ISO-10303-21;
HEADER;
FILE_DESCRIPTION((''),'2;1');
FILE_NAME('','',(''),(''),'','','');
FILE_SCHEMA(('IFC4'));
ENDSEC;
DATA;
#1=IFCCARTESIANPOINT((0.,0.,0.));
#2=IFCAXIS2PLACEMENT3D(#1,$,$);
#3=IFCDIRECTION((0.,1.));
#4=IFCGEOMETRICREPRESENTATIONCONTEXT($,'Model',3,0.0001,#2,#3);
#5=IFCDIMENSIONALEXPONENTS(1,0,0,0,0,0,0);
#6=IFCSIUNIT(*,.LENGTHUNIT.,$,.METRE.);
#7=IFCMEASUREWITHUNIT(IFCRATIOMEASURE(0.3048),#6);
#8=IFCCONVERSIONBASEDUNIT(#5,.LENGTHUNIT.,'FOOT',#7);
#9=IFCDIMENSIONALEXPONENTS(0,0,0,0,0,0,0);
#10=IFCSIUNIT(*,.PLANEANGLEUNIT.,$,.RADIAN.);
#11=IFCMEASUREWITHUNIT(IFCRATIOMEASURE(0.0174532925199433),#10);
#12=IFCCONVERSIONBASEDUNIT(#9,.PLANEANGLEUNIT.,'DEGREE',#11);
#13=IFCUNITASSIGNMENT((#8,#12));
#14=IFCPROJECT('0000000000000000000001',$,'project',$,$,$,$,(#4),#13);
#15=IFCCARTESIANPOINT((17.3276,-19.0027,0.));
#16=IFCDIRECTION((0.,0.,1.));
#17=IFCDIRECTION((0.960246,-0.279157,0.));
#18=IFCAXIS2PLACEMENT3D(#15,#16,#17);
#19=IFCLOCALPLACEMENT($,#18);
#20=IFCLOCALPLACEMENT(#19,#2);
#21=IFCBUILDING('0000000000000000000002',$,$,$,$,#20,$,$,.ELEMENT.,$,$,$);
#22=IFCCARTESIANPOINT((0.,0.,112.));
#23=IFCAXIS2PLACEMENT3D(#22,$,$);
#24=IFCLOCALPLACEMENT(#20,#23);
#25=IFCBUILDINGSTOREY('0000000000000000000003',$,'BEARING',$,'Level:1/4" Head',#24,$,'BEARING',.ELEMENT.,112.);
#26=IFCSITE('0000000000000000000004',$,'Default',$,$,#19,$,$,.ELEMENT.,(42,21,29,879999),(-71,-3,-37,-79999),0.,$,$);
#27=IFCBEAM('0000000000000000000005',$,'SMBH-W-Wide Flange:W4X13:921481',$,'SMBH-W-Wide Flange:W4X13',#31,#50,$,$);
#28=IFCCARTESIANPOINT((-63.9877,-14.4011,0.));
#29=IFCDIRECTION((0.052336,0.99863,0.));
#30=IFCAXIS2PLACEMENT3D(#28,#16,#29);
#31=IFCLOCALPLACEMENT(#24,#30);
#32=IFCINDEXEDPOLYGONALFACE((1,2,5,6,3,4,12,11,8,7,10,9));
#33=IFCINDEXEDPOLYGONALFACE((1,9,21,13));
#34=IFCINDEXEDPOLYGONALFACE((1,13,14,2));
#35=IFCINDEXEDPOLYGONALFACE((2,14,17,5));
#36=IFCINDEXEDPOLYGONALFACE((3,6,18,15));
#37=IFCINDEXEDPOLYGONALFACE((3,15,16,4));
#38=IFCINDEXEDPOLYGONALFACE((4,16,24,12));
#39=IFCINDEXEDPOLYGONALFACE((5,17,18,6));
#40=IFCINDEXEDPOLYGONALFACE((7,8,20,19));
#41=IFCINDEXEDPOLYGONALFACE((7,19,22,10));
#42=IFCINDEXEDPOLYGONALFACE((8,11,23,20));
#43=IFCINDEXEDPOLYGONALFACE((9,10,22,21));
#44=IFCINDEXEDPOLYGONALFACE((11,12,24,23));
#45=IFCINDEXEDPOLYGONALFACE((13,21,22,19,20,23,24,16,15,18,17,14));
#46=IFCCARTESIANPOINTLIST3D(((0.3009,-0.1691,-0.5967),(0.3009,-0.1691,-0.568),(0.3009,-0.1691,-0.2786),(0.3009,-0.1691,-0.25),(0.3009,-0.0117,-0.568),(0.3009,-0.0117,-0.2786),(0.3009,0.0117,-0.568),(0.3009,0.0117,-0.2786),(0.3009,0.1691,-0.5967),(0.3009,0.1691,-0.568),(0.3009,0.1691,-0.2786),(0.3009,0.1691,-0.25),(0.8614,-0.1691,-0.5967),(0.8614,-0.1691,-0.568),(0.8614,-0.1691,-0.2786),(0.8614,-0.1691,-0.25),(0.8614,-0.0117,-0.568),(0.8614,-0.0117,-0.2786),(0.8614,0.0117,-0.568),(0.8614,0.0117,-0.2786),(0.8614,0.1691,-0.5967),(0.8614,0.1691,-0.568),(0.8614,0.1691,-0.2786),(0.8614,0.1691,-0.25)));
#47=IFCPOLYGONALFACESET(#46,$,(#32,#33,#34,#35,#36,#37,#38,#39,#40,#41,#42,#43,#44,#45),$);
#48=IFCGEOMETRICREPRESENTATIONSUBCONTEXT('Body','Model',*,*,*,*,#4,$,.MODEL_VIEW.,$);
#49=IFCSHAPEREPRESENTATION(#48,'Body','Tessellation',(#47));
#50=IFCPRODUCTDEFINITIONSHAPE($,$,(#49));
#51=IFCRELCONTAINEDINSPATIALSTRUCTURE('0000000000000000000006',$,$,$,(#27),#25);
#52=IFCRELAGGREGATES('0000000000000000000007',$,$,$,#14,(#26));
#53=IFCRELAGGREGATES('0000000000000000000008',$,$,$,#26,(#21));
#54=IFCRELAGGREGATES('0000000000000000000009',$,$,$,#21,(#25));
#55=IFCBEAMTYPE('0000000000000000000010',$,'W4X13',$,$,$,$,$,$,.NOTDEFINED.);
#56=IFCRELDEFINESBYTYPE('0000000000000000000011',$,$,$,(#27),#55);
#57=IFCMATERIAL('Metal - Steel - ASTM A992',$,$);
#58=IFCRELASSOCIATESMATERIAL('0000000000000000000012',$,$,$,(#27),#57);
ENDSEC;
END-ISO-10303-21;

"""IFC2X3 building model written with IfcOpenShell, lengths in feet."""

from ifc_helpers import new_model, entity, si_unit, converted_unit, direction, frame, frame_2d, origin, place, context, subcontext, project, spatial, i_section, extrude, material, type_object, element, save


model = new_model("IFC2X3")

# Units and contexts
model_context = context("Model", 3, precision=0.0001, world=origin(), true_north=direction((0.0, 1.0)))
body_context = subcontext(model_context, "Body", "Model", "MODEL_VIEW")
ifc_project = project(units=[converted_unit("LENGTHUNIT", "FOOT", entity("IfcRatioMeasure", 0.3048), si_unit("LENGTHUNIT", "METRE"), dimensions=[1, 0, 0, 0, 0, 0, 0]), converted_unit("PLANEANGLEUNIT", "DEGREE", entity("IfcRatioMeasure", 0.0174532925199433), si_unit("PLANEANGLEUNIT", "RADIAN"), dimensions=[0, 0, 0, 0, 0, 0, 0])], contexts=[model_context])

# Site, building, storey
site_placement = place(None, frame((17.3276, -19.0027, 0.0), z_axis=(0.0, 0.0, 1.0), x_axis=(0.960246, -0.279157, 0.0)))
site = spatial("IfcSite", under=ifc_project, at=site_placement, Name="Default", CompositionType="ELEMENT", RefLatitude=(42, 21, 29, 879999), RefLongitude=(-71, -3, -37, -79999), RefElevation=0.0)
building_placement = place(site_placement, origin())
building = spatial("IfcBuilding", under=site, at=building_placement, CompositionType="ELEMENT")
storey_placement = place(building_placement, frame((0.0, 0.0, 112.0)))
storey = spatial("IfcBuildingStorey", under=building, at=storey_placement, Name="BEARING", ObjectType="Level:1/4\" Head", LongName="BEARING", CompositionType="ELEMENT", Elevation=112.0)

# Shared definitions
ifc_material_1 = material(Name="Metal - Steel - ASTM A992")

# Beam
beam_type_1 = type_object("IfcBeamType", Name="W4X13", PredefinedType="NOTDEFINED")
beam_1_placement = place(storey_placement, frame((-63.9877, -14.4011, 0.0), z_axis=(0.0, 0.0, 1.0), x_axis=(0.052336, 0.99863, 0.0)))
element("IfcBeam", 1, at=beam_1_placement, inside=storey, type_object=beam_type_1, material=ifc_material_1, Name="SMBH-W-Wide Flange:W4X13:921481", ObjectType="SMBH-W-Wide Flange:W4X13", context=body_context, shape_type="SweptSolid", body=[
    extrude(i_section(OverallWidth=0.3382, OverallDepth=0.3467, WebThickness=0.0234, FlangeThickness=0.0286, at=frame_2d((0.0, 0.0), x_axis=(0.0, 1.0))), frame((0.3009, 0.0, -0.4233), z_axis=(1.0, 0.0, 0.0), x_axis=(0.0, 0.0, -1.0)), (0.0, 0.0, 1.0), 0.5605),
])

save(model, "model.ifc")
